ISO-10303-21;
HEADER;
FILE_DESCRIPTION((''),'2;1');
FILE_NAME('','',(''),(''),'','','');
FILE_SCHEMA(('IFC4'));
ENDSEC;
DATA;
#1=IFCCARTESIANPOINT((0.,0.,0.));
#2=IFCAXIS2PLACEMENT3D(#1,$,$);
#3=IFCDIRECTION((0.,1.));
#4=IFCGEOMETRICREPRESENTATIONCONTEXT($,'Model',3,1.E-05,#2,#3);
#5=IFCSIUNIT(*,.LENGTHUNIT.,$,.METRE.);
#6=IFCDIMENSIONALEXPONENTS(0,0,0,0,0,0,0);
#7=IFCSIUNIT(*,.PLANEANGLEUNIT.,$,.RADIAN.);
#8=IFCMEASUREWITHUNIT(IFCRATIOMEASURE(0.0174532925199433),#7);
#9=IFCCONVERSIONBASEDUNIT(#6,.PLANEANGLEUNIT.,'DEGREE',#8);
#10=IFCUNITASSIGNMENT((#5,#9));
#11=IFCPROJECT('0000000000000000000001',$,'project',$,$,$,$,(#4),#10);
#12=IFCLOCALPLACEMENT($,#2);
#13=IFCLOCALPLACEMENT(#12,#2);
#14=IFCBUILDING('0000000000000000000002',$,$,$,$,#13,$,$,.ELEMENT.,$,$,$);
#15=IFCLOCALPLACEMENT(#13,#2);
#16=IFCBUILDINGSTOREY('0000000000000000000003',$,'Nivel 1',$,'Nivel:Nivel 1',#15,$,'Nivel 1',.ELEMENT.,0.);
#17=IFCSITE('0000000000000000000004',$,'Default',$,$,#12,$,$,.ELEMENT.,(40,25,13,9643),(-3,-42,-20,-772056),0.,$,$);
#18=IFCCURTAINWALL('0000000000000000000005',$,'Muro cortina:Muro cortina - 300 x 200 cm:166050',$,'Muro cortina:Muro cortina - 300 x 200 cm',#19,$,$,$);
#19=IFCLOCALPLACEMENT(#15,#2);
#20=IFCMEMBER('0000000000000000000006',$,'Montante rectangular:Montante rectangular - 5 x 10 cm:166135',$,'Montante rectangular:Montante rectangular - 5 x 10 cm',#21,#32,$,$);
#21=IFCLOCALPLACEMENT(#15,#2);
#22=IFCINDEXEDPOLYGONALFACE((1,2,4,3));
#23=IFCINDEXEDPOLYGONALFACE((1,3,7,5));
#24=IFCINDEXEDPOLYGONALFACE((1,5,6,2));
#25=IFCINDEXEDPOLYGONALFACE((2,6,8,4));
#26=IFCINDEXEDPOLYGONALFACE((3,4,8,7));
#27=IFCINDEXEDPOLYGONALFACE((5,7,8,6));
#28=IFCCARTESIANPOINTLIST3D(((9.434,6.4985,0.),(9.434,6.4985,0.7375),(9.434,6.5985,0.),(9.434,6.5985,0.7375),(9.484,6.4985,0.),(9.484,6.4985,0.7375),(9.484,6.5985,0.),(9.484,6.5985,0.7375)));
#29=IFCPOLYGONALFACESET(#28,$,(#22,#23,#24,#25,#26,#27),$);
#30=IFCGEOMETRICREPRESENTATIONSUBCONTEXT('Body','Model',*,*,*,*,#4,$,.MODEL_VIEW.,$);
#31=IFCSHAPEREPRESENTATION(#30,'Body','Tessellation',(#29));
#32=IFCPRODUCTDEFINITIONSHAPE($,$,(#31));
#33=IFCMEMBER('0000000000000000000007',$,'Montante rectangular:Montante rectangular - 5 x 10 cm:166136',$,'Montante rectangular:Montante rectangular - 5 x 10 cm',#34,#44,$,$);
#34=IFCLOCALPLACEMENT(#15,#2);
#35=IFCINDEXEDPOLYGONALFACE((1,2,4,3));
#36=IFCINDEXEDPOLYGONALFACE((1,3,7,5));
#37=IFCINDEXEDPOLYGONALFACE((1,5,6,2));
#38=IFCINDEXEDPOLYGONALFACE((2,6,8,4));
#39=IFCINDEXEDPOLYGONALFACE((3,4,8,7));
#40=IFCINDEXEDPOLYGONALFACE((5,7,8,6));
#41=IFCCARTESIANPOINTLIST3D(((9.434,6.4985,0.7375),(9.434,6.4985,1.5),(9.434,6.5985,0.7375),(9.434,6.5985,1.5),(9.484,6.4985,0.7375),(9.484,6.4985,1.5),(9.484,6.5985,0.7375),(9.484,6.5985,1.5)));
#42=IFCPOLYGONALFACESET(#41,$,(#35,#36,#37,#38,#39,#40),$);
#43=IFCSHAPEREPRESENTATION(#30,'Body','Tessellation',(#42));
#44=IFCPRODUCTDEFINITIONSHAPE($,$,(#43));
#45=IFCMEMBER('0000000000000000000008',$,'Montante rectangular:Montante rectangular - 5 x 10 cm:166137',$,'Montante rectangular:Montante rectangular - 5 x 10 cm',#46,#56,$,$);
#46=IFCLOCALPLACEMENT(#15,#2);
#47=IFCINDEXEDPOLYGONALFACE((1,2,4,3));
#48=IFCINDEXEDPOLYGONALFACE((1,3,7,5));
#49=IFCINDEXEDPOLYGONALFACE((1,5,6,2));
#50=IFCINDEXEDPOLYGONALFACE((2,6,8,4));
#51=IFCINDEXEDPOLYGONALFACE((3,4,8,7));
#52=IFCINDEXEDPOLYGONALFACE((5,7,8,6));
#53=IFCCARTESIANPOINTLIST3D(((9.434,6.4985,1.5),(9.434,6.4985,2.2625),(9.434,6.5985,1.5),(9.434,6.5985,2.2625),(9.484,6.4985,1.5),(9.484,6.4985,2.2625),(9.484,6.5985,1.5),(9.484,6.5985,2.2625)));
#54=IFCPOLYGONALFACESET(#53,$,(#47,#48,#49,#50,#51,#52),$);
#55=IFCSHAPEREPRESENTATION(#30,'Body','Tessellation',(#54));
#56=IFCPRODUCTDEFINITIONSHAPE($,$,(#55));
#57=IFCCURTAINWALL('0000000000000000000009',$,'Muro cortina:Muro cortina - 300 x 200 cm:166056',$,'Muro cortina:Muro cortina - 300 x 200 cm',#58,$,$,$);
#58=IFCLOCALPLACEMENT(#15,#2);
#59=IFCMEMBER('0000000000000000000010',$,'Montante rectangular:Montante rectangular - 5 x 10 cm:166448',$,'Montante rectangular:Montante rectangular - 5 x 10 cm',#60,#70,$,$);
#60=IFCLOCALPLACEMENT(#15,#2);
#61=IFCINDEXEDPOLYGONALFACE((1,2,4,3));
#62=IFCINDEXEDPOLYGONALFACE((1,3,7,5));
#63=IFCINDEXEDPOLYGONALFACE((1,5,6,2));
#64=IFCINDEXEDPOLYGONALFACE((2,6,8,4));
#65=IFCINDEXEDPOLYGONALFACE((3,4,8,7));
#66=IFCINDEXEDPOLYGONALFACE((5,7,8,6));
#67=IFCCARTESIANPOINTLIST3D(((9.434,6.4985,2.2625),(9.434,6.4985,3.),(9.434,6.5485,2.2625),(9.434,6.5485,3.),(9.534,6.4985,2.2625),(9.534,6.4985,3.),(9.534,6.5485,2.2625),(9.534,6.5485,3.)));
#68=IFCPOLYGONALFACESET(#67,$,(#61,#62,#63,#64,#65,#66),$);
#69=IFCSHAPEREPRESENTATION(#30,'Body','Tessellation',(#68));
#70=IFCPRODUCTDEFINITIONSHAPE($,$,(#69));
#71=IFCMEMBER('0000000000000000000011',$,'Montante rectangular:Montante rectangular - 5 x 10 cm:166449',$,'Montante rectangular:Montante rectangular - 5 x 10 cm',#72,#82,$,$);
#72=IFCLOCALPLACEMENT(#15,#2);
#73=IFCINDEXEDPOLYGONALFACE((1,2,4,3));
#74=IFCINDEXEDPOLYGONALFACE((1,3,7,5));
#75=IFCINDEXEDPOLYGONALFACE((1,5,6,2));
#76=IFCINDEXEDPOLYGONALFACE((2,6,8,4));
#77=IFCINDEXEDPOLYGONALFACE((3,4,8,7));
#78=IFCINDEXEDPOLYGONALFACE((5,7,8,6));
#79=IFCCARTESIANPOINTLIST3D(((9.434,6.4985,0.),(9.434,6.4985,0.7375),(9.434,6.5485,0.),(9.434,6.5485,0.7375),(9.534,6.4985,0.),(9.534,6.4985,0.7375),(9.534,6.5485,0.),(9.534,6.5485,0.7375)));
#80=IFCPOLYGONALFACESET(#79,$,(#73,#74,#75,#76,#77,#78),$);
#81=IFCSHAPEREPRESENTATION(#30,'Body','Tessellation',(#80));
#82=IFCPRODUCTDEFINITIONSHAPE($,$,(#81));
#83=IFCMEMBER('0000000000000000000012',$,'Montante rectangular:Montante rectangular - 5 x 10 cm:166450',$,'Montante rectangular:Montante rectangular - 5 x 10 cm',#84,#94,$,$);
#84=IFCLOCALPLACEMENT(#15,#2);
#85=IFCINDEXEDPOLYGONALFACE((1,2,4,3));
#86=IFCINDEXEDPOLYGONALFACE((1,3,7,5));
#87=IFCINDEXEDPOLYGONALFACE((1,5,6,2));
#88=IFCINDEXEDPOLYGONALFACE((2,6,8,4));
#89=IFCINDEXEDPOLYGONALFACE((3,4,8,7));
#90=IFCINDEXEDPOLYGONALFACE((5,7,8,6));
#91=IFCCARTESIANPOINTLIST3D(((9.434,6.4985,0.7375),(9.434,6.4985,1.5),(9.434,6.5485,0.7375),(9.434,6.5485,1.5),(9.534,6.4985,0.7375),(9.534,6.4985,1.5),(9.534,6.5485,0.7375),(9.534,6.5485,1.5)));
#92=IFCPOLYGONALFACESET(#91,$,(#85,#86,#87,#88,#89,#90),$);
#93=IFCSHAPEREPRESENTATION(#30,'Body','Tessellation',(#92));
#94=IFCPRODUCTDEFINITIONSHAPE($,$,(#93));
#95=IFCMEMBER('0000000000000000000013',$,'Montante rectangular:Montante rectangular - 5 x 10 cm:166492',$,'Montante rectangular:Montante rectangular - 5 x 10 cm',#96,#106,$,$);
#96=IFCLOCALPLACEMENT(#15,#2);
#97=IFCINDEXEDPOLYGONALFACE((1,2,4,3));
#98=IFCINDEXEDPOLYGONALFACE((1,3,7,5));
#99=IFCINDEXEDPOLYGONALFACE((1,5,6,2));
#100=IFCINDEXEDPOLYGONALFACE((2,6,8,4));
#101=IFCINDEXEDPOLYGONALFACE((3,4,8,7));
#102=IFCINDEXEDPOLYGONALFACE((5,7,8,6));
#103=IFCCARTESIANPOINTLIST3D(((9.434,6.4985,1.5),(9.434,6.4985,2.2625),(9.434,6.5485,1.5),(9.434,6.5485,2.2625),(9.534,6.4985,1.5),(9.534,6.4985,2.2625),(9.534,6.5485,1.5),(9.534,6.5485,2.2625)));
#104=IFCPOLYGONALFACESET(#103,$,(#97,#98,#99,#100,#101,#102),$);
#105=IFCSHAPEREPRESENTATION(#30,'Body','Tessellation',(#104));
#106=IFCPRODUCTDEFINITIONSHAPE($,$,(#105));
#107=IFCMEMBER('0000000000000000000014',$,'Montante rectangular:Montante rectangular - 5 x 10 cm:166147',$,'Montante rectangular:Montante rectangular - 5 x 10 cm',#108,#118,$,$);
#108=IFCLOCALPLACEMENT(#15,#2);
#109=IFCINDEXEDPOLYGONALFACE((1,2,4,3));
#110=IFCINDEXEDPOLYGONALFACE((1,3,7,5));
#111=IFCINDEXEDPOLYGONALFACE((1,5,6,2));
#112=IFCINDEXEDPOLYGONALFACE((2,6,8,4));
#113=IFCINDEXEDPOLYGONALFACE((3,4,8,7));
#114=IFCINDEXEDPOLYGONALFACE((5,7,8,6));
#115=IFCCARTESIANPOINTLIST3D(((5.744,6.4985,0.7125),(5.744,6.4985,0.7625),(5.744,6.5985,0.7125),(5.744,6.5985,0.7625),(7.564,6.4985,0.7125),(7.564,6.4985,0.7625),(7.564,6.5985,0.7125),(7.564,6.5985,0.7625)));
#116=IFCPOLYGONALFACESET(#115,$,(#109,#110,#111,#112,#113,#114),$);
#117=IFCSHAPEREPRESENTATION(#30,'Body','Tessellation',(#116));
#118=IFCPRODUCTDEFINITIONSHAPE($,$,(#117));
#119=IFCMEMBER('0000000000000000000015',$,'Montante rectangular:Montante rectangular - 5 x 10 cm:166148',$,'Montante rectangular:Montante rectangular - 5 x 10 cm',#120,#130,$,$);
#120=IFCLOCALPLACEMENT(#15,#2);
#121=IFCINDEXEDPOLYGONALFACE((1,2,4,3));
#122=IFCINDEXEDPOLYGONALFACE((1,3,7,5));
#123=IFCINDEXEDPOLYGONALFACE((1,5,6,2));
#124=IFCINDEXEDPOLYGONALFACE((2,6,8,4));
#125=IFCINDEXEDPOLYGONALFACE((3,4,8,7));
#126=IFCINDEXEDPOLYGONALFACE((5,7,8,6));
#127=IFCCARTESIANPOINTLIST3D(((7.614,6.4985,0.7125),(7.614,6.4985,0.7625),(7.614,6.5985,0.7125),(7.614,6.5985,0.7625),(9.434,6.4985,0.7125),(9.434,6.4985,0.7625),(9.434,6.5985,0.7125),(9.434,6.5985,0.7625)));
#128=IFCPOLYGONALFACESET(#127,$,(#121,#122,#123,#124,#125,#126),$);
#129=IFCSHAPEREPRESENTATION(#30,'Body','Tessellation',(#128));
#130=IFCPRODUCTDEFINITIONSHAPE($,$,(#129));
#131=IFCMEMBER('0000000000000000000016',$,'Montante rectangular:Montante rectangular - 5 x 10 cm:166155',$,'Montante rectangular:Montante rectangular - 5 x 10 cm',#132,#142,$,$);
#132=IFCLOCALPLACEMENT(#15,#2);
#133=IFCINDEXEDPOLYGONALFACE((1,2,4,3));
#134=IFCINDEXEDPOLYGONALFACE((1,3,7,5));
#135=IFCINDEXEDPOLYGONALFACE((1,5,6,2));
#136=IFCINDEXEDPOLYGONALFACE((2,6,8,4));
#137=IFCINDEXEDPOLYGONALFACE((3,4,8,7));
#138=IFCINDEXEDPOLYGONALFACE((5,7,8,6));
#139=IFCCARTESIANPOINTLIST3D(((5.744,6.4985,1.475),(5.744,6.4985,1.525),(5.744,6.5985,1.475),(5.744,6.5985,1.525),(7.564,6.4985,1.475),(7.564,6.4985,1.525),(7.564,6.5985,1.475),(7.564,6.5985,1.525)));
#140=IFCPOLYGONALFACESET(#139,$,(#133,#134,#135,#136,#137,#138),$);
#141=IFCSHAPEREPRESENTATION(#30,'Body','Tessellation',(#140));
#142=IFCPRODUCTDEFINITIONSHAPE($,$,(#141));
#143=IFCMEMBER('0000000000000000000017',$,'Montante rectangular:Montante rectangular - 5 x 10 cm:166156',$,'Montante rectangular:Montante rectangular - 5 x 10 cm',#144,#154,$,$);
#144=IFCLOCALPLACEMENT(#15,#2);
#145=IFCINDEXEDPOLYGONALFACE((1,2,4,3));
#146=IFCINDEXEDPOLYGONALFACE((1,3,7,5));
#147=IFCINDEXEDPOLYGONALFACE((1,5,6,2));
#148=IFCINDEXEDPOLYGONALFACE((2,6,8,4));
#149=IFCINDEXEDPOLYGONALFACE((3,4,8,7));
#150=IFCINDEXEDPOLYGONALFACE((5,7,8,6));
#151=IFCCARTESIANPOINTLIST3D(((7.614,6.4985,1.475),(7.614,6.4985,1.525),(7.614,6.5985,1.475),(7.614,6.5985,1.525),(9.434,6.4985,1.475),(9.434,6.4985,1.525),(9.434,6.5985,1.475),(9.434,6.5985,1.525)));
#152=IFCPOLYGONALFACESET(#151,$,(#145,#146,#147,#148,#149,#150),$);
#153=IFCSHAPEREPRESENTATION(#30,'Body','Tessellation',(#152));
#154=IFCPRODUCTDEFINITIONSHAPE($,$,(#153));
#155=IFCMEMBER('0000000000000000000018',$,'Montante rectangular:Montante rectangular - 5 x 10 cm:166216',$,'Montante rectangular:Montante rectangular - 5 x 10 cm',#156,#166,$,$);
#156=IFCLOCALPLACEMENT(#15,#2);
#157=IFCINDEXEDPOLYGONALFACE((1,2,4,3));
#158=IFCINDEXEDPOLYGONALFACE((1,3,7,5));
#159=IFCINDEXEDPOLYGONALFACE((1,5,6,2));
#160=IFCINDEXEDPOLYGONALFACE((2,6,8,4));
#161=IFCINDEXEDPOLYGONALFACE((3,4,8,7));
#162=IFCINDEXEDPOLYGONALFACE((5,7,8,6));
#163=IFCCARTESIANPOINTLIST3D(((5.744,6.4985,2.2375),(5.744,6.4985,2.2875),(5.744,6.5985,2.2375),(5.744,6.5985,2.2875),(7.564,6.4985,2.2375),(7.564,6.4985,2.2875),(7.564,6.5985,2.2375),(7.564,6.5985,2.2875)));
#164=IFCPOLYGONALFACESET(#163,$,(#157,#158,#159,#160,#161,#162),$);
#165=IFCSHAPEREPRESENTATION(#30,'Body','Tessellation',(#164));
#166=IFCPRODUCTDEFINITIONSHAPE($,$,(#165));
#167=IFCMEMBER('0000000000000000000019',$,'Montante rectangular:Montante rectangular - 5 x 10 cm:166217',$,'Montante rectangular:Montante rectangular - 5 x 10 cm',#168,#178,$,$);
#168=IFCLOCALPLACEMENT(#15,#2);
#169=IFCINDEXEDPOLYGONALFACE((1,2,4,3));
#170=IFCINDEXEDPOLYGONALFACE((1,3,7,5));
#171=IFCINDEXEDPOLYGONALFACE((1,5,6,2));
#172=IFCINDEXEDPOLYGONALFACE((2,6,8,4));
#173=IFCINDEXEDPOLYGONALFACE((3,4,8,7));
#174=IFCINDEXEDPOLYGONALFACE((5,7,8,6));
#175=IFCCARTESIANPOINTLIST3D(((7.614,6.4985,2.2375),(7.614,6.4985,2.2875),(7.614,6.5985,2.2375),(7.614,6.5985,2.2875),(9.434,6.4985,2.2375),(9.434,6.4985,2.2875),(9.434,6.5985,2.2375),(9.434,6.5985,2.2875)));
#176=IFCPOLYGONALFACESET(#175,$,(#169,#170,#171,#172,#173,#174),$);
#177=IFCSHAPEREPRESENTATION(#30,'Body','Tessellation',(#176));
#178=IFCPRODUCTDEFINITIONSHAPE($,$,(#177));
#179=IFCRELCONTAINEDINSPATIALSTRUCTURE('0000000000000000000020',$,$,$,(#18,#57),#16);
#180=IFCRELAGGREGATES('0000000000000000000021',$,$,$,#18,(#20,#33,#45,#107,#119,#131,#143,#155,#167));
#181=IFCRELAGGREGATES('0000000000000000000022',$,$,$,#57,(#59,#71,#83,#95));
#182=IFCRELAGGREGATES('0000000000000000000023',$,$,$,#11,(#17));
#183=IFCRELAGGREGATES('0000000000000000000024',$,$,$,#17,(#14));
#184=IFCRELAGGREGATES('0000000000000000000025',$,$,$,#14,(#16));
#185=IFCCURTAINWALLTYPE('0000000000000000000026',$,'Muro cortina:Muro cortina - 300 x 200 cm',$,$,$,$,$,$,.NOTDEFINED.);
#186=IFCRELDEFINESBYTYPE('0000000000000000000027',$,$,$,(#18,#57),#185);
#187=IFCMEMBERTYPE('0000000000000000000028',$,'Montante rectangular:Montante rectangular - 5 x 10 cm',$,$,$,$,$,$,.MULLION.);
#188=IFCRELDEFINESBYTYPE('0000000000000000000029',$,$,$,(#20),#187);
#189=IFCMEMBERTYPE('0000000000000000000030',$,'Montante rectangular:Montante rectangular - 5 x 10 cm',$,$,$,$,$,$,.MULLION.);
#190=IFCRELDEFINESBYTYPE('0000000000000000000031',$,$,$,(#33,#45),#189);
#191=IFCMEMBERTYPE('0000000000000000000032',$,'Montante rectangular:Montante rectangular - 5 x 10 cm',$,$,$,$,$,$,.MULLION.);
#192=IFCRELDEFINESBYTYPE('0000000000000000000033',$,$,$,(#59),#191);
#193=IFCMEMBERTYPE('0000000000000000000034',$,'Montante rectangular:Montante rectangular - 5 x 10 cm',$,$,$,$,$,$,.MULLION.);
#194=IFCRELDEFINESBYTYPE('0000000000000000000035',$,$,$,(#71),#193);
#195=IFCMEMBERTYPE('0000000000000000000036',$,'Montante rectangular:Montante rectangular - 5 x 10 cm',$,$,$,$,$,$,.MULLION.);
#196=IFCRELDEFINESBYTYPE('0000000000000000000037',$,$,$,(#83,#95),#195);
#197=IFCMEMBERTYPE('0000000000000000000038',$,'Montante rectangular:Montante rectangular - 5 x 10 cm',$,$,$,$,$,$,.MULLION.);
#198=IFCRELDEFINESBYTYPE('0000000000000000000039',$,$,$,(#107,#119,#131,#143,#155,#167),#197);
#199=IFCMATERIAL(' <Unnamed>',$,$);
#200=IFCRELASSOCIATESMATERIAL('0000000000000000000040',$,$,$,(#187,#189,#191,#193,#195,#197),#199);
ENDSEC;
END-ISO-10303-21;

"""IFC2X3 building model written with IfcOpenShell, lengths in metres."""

from ifc_helpers import new_model, entity, si_unit, converted_unit, direction, frame, origin, origin_2d_with_axis, place, context, subcontext, project, spatial, rectangle, extrude, source, transform, mapped, material, type_object, type_shapes, element, aggregate, save


model = new_model("IFC2X3")

# Units and contexts
model_context = context("Model", 3, precision=1e-05, world=origin(), true_north=direction((0.0, 1.0)))
body_context = subcontext(model_context, "Body", "Model", "MODEL_VIEW")
ifc_project = project(units=[si_unit("LENGTHUNIT", "METRE"), converted_unit("PLANEANGLEUNIT", "DEGREE", entity("IfcRatioMeasure", 0.0174532925199433), si_unit("PLANEANGLEUNIT", "RADIAN"), dimensions=[0, 0, 0, 0, 0, 0, 0])], contexts=[model_context])

# Site, building, storey
site_placement = place(None, origin())
site = spatial("IfcSite", under=ifc_project, at=site_placement, Name="Default", CompositionType="ELEMENT", RefLatitude=(40, 25, 13, 9643), RefLongitude=(-3, -42, -20, -772056), RefElevation=0.0)
building_placement = place(site_placement, origin())
building = spatial("IfcBuilding", under=site, at=building_placement, CompositionType="ELEMENT")
storey_placement = place(building_placement, origin())
storey = spatial("IfcBuildingStorey", under=building, at=storey_placement, Name="Nivel 1", ObjectType="Nivel:Nivel 1", LongName="Nivel 1", CompositionType="ELEMENT", Elevation=0.0)

# Curtain walls, members
curtain_wall_type = type_object("IfcCurtainWallType", Name="Muro cortina:Muro cortina - 300 x 200 cm", PredefinedType="NOTDEFINED")
curtain_wall_1_placement = place(storey_placement, origin())
curtain_wall_1 = element("IfcCurtainWall", 1, at=curtain_wall_1_placement, inside=storey, type_object=curtain_wall_type, Name="Muro cortina:Muro cortina - 300 x 200 cm:166050", ObjectType="Muro cortina:Muro cortina - 300 x 200 cm")
ifc_material_1 = material(Name=" <Unnamed>")
member_type_1 = type_object("IfcMemberType", Name="Montante rectangular:Montante rectangular - 5 x 10 cm", PredefinedType="MULLION", material=ifc_material_1)
shared_shape_1 = source(origin(), body_context, "Body", "SweptSolid", [
    extrude(rectangle(XDim=0.1, YDim=0.05, at=origin_2d_with_axis()), frame((-0.025, 0.0, -0.7375), z_axis=(0.0, 0.0, 1.0), x_axis=(0.0, -1.0, 0.0)), (0.0, 0.0, 1.0), 0.7375),
])
type_shapes(member_type_1, [shared_shape_1])
member_1_placement = place(storey_placement, frame((9.484, 6.5485, 0.0), z_axis=(0.0, 0.0, -1.0), x_axis=(1.0, 0.0, 0.0)))
member_1 = element("IfcMember", 2, at=member_1_placement, type_object=member_type_1, Name="Montante rectangular:Montante rectangular - 5 x 10 cm:166135", ObjectType="Montante rectangular:Montante rectangular - 5 x 10 cm", context=body_context, shape_type="MappedRepresentation", body=[
    mapped(shared_shape_1, transform((0.0, 0.0, 0.0), scale=1.0)),
])
member_type_2 = type_object("IfcMemberType", Name="Montante rectangular:Montante rectangular - 5 x 10 cm", PredefinedType="MULLION", material=ifc_material_1)
shared_shape_2 = source(origin(), body_context, "Body", "SweptSolid", [
    extrude(rectangle(XDim=0.1, YDim=0.05, at=origin_2d_with_axis()), frame((-0.025, 0.0, -0.7625), z_axis=(0.0, 0.0, 1.0), x_axis=(0.0, -1.0, 0.0)), (0.0, 0.0, 1.0), 0.7625),
])
type_shapes(member_type_2, [shared_shape_2])
member_2_placement = place(storey_placement, frame((9.484, 6.5485, 0.7375), z_axis=(0.0, 0.0, -1.0), x_axis=(1.0, 0.0, 0.0)))
member_2 = element("IfcMember", 3, at=member_2_placement, type_object=member_type_2, Name="Montante rectangular:Montante rectangular - 5 x 10 cm:166136", ObjectType="Montante rectangular:Montante rectangular - 5 x 10 cm", context=body_context, shape_type="MappedRepresentation", body=[
    mapped(shared_shape_2, transform((0.0, 0.0, 0.0), scale=1.0)),
])
member_3_placement = place(storey_placement, frame((9.484, 6.5485, 1.5), z_axis=(0.0, 0.0, -1.0), x_axis=(1.0, 0.0, 0.0)))
member_3 = element("IfcMember", 4, at=member_3_placement, type_object=member_type_2, Name="Montante rectangular:Montante rectangular - 5 x 10 cm:166137", ObjectType="Montante rectangular:Montante rectangular - 5 x 10 cm", context=body_context, shape_type="MappedRepresentation", body=[
    mapped(shared_shape_2, transform((0.0, 0.0, 0.0), scale=1.0)),
])
curtain_wall_2_placement = place(storey_placement, origin())
curtain_wall_2 = element("IfcCurtainWall", 5, at=curtain_wall_2_placement, inside=storey, type_object=curtain_wall_type, Name="Muro cortina:Muro cortina - 300 x 200 cm:166056", ObjectType="Muro cortina:Muro cortina - 300 x 200 cm")
member_type_3 = type_object("IfcMemberType", Name="Montante rectangular:Montante rectangular - 5 x 10 cm", PredefinedType="MULLION", material=ifc_material_1)
shared_shape_3 = source(origin(), body_context, "Body", "SweptSolid", [
    extrude(rectangle(XDim=0.1, YDim=0.05, at=origin_2d_with_axis()), frame((-0.025, 0.0, -0.7375), z_axis=(0.0, 0.0, 1.0), x_axis=(0.0, -1.0, 0.0)), (0.0, 0.0, 1.0), 0.7375),
])
type_shapes(member_type_3, [shared_shape_3])
member_4_placement = place(storey_placement, frame((9.484, 6.5485, 3.0), z_axis=(0.0, 0.0, 1.0), x_axis=(0.0, 1.0, 0.0)))
member_4 = element("IfcMember", 6, at=member_4_placement, type_object=member_type_3, Name="Montante rectangular:Montante rectangular - 5 x 10 cm:166448", ObjectType="Montante rectangular:Montante rectangular - 5 x 10 cm", context=body_context, shape_type="MappedRepresentation", body=[
    mapped(shared_shape_3, transform((0.0, 0.0, 0.0), scale=1.0)),
])
member_type_4 = type_object("IfcMemberType", Name="Montante rectangular:Montante rectangular - 5 x 10 cm", PredefinedType="MULLION", material=ifc_material_1)
shared_shape_4 = source(origin(), body_context, "Body", "SweptSolid", [
    extrude(rectangle(XDim=0.1, YDim=0.05, at=origin_2d_with_axis()), frame((-0.025, 0.0, -0.7375), z_axis=(0.0, 0.0, 1.0), x_axis=(0.0, -1.0, 0.0)), (0.0, 0.0, 1.0), 0.7375),
])
type_shapes(member_type_4, [shared_shape_4])
member_5_placement = place(storey_placement, frame((9.484, 6.5485, 0.7375), z_axis=(0.0, 0.0, 1.0), x_axis=(0.0, 1.0, 0.0)))
member_5 = element("IfcMember", 7, at=member_5_placement, type_object=member_type_4, Name="Montante rectangular:Montante rectangular - 5 x 10 cm:166449", ObjectType="Montante rectangular:Montante rectangular - 5 x 10 cm", context=body_context, shape_type="MappedRepresentation", body=[
    mapped(shared_shape_4, transform((0.0, 0.0, 0.0), scale=1.0)),
])
member_type_5 = type_object("IfcMemberType", Name="Montante rectangular:Montante rectangular - 5 x 10 cm", PredefinedType="MULLION", material=ifc_material_1)
shared_shape_5 = source(origin(), body_context, "Body", "SweptSolid", [
    extrude(rectangle(XDim=0.1, YDim=0.05, at=origin_2d_with_axis()), frame((-0.025, 0.0, -0.7625), z_axis=(0.0, 0.0, 1.0), x_axis=(0.0, -1.0, 0.0)), (0.0, 0.0, 1.0), 0.7625),
])
type_shapes(member_type_5, [shared_shape_5])
member_6_placement = place(storey_placement, frame((9.484, 6.5485, 1.5), z_axis=(0.0, 0.0, 1.0), x_axis=(0.0, 1.0, 0.0)))
member_6 = element("IfcMember", 8, at=member_6_placement, type_object=member_type_5, Name="Montante rectangular:Montante rectangular - 5 x 10 cm:166450", ObjectType="Montante rectangular:Montante rectangular - 5 x 10 cm", context=body_context, shape_type="MappedRepresentation", body=[
    mapped(shared_shape_5, transform((0.0, 0.0, 0.0), scale=1.0)),
])
member_7_placement = place(storey_placement, frame((9.484, 6.5485, 2.2625), z_axis=(0.0, 0.0, 1.0), x_axis=(0.0, 1.0, 0.0)))
member_7 = element("IfcMember", 9, at=member_7_placement, type_object=member_type_5, Name="Montante rectangular:Montante rectangular - 5 x 10 cm:166492", ObjectType="Montante rectangular:Montante rectangular - 5 x 10 cm", context=body_context, shape_type="MappedRepresentation", body=[
    mapped(shared_shape_5, transform((0.0, 0.0, 0.0), scale=1.0)),
])

# Members
member_type_6 = type_object("IfcMemberType", Name="Montante rectangular:Montante rectangular - 5 x 10 cm", PredefinedType="MULLION", material=ifc_material_1)
shared_shape_6 = source(origin(), body_context, "Body", "SweptSolid", [
    extrude(rectangle(XDim=0.1, YDim=0.05, at=origin_2d_with_axis()), frame((0.0, 0.0, -1.82), z_axis=(0.0, 0.0, 1.0), x_axis=(0.0, -1.0, 0.0)), (0.0, 0.0, 1.0), 1.82),
])
type_shapes(member_type_6, [shared_shape_6])
member_8_placement = place(storey_placement, frame((7.564, 6.5485, 0.7375), z_axis=(1.0, 0.0, 0.0), x_axis=(0.0, 0.0, 1.0)))
member_8 = element("IfcMember", 10, at=member_8_placement, type_object=member_type_6, Name="Montante rectangular:Montante rectangular - 5 x 10 cm:166147", ObjectType="Montante rectangular:Montante rectangular - 5 x 10 cm", context=body_context, shape_type="MappedRepresentation", body=[
    mapped(shared_shape_6, transform((0.0, 0.0, 0.0), scale=1.0)),
])
member_9_placement = place(storey_placement, frame((9.434, 6.5485, 0.7375), z_axis=(1.0, 0.0, 0.0), x_axis=(0.0, 0.0, 1.0)))
member_9 = element("IfcMember", 11, at=member_9_placement, type_object=member_type_6, Name="Montante rectangular:Montante rectangular - 5 x 10 cm:166148", ObjectType="Montante rectangular:Montante rectangular - 5 x 10 cm", context=body_context, shape_type="MappedRepresentation", body=[
    mapped(shared_shape_6, transform((0.0, 0.0, 0.0), scale=1.0)),
])
member_10_placement = place(storey_placement, frame((7.564, 6.5485, 1.5), z_axis=(1.0, 0.0, 0.0), x_axis=(0.0, 0.0, 1.0)))
member_10 = element("IfcMember", 12, at=member_10_placement, type_object=member_type_6, Name="Montante rectangular:Montante rectangular - 5 x 10 cm:166155", ObjectType="Montante rectangular:Montante rectangular - 5 x 10 cm", context=body_context, shape_type="MappedRepresentation", body=[
    mapped(shared_shape_6, transform((0.0, 0.0, 0.0), scale=1.0)),
])
member_11_placement = place(storey_placement, frame((9.434, 6.5485, 1.5), z_axis=(1.0, 0.0, 0.0), x_axis=(0.0, 0.0, 1.0)))
member_11 = element("IfcMember", 13, at=member_11_placement, type_object=member_type_6, Name="Montante rectangular:Montante rectangular - 5 x 10 cm:166156", ObjectType="Montante rectangular:Montante rectangular - 5 x 10 cm", context=body_context, shape_type="MappedRepresentation", body=[
    mapped(shared_shape_6, transform((0.0, 0.0, 0.0), scale=1.0)),
])
member_12_placement = place(storey_placement, frame((7.564, 6.5485, 2.2625), z_axis=(1.0, 0.0, 0.0), x_axis=(0.0, 0.0, 1.0)))
member_12 = element("IfcMember", 14, at=member_12_placement, type_object=member_type_6, Name="Montante rectangular:Montante rectangular - 5 x 10 cm:166216", ObjectType="Montante rectangular:Montante rectangular - 5 x 10 cm", context=body_context, shape_type="MappedRepresentation", body=[
    mapped(shared_shape_6, transform((0.0, 0.0, 0.0), scale=1.0)),
])
member_13_placement = place(storey_placement, frame((9.434, 6.5485, 2.2625), z_axis=(1.0, 0.0, 0.0), x_axis=(0.0, 0.0, 1.0)))
member_13 = element("IfcMember", 15, at=member_13_placement, type_object=member_type_6, Name="Montante rectangular:Montante rectangular - 5 x 10 cm:166217", ObjectType="Montante rectangular:Montante rectangular - 5 x 10 cm", context=body_context, shape_type="MappedRepresentation", body=[
    mapped(shared_shape_6, transform((0.0, 0.0, 0.0), scale=1.0)),
])

aggregate(curtain_wall_1, [member_1, member_2, member_3, member_8, member_9, member_10, member_11, member_12, member_13])
aggregate(curtain_wall_2, [member_4, member_5, member_6, member_7])

save(model, "model.ifc")
